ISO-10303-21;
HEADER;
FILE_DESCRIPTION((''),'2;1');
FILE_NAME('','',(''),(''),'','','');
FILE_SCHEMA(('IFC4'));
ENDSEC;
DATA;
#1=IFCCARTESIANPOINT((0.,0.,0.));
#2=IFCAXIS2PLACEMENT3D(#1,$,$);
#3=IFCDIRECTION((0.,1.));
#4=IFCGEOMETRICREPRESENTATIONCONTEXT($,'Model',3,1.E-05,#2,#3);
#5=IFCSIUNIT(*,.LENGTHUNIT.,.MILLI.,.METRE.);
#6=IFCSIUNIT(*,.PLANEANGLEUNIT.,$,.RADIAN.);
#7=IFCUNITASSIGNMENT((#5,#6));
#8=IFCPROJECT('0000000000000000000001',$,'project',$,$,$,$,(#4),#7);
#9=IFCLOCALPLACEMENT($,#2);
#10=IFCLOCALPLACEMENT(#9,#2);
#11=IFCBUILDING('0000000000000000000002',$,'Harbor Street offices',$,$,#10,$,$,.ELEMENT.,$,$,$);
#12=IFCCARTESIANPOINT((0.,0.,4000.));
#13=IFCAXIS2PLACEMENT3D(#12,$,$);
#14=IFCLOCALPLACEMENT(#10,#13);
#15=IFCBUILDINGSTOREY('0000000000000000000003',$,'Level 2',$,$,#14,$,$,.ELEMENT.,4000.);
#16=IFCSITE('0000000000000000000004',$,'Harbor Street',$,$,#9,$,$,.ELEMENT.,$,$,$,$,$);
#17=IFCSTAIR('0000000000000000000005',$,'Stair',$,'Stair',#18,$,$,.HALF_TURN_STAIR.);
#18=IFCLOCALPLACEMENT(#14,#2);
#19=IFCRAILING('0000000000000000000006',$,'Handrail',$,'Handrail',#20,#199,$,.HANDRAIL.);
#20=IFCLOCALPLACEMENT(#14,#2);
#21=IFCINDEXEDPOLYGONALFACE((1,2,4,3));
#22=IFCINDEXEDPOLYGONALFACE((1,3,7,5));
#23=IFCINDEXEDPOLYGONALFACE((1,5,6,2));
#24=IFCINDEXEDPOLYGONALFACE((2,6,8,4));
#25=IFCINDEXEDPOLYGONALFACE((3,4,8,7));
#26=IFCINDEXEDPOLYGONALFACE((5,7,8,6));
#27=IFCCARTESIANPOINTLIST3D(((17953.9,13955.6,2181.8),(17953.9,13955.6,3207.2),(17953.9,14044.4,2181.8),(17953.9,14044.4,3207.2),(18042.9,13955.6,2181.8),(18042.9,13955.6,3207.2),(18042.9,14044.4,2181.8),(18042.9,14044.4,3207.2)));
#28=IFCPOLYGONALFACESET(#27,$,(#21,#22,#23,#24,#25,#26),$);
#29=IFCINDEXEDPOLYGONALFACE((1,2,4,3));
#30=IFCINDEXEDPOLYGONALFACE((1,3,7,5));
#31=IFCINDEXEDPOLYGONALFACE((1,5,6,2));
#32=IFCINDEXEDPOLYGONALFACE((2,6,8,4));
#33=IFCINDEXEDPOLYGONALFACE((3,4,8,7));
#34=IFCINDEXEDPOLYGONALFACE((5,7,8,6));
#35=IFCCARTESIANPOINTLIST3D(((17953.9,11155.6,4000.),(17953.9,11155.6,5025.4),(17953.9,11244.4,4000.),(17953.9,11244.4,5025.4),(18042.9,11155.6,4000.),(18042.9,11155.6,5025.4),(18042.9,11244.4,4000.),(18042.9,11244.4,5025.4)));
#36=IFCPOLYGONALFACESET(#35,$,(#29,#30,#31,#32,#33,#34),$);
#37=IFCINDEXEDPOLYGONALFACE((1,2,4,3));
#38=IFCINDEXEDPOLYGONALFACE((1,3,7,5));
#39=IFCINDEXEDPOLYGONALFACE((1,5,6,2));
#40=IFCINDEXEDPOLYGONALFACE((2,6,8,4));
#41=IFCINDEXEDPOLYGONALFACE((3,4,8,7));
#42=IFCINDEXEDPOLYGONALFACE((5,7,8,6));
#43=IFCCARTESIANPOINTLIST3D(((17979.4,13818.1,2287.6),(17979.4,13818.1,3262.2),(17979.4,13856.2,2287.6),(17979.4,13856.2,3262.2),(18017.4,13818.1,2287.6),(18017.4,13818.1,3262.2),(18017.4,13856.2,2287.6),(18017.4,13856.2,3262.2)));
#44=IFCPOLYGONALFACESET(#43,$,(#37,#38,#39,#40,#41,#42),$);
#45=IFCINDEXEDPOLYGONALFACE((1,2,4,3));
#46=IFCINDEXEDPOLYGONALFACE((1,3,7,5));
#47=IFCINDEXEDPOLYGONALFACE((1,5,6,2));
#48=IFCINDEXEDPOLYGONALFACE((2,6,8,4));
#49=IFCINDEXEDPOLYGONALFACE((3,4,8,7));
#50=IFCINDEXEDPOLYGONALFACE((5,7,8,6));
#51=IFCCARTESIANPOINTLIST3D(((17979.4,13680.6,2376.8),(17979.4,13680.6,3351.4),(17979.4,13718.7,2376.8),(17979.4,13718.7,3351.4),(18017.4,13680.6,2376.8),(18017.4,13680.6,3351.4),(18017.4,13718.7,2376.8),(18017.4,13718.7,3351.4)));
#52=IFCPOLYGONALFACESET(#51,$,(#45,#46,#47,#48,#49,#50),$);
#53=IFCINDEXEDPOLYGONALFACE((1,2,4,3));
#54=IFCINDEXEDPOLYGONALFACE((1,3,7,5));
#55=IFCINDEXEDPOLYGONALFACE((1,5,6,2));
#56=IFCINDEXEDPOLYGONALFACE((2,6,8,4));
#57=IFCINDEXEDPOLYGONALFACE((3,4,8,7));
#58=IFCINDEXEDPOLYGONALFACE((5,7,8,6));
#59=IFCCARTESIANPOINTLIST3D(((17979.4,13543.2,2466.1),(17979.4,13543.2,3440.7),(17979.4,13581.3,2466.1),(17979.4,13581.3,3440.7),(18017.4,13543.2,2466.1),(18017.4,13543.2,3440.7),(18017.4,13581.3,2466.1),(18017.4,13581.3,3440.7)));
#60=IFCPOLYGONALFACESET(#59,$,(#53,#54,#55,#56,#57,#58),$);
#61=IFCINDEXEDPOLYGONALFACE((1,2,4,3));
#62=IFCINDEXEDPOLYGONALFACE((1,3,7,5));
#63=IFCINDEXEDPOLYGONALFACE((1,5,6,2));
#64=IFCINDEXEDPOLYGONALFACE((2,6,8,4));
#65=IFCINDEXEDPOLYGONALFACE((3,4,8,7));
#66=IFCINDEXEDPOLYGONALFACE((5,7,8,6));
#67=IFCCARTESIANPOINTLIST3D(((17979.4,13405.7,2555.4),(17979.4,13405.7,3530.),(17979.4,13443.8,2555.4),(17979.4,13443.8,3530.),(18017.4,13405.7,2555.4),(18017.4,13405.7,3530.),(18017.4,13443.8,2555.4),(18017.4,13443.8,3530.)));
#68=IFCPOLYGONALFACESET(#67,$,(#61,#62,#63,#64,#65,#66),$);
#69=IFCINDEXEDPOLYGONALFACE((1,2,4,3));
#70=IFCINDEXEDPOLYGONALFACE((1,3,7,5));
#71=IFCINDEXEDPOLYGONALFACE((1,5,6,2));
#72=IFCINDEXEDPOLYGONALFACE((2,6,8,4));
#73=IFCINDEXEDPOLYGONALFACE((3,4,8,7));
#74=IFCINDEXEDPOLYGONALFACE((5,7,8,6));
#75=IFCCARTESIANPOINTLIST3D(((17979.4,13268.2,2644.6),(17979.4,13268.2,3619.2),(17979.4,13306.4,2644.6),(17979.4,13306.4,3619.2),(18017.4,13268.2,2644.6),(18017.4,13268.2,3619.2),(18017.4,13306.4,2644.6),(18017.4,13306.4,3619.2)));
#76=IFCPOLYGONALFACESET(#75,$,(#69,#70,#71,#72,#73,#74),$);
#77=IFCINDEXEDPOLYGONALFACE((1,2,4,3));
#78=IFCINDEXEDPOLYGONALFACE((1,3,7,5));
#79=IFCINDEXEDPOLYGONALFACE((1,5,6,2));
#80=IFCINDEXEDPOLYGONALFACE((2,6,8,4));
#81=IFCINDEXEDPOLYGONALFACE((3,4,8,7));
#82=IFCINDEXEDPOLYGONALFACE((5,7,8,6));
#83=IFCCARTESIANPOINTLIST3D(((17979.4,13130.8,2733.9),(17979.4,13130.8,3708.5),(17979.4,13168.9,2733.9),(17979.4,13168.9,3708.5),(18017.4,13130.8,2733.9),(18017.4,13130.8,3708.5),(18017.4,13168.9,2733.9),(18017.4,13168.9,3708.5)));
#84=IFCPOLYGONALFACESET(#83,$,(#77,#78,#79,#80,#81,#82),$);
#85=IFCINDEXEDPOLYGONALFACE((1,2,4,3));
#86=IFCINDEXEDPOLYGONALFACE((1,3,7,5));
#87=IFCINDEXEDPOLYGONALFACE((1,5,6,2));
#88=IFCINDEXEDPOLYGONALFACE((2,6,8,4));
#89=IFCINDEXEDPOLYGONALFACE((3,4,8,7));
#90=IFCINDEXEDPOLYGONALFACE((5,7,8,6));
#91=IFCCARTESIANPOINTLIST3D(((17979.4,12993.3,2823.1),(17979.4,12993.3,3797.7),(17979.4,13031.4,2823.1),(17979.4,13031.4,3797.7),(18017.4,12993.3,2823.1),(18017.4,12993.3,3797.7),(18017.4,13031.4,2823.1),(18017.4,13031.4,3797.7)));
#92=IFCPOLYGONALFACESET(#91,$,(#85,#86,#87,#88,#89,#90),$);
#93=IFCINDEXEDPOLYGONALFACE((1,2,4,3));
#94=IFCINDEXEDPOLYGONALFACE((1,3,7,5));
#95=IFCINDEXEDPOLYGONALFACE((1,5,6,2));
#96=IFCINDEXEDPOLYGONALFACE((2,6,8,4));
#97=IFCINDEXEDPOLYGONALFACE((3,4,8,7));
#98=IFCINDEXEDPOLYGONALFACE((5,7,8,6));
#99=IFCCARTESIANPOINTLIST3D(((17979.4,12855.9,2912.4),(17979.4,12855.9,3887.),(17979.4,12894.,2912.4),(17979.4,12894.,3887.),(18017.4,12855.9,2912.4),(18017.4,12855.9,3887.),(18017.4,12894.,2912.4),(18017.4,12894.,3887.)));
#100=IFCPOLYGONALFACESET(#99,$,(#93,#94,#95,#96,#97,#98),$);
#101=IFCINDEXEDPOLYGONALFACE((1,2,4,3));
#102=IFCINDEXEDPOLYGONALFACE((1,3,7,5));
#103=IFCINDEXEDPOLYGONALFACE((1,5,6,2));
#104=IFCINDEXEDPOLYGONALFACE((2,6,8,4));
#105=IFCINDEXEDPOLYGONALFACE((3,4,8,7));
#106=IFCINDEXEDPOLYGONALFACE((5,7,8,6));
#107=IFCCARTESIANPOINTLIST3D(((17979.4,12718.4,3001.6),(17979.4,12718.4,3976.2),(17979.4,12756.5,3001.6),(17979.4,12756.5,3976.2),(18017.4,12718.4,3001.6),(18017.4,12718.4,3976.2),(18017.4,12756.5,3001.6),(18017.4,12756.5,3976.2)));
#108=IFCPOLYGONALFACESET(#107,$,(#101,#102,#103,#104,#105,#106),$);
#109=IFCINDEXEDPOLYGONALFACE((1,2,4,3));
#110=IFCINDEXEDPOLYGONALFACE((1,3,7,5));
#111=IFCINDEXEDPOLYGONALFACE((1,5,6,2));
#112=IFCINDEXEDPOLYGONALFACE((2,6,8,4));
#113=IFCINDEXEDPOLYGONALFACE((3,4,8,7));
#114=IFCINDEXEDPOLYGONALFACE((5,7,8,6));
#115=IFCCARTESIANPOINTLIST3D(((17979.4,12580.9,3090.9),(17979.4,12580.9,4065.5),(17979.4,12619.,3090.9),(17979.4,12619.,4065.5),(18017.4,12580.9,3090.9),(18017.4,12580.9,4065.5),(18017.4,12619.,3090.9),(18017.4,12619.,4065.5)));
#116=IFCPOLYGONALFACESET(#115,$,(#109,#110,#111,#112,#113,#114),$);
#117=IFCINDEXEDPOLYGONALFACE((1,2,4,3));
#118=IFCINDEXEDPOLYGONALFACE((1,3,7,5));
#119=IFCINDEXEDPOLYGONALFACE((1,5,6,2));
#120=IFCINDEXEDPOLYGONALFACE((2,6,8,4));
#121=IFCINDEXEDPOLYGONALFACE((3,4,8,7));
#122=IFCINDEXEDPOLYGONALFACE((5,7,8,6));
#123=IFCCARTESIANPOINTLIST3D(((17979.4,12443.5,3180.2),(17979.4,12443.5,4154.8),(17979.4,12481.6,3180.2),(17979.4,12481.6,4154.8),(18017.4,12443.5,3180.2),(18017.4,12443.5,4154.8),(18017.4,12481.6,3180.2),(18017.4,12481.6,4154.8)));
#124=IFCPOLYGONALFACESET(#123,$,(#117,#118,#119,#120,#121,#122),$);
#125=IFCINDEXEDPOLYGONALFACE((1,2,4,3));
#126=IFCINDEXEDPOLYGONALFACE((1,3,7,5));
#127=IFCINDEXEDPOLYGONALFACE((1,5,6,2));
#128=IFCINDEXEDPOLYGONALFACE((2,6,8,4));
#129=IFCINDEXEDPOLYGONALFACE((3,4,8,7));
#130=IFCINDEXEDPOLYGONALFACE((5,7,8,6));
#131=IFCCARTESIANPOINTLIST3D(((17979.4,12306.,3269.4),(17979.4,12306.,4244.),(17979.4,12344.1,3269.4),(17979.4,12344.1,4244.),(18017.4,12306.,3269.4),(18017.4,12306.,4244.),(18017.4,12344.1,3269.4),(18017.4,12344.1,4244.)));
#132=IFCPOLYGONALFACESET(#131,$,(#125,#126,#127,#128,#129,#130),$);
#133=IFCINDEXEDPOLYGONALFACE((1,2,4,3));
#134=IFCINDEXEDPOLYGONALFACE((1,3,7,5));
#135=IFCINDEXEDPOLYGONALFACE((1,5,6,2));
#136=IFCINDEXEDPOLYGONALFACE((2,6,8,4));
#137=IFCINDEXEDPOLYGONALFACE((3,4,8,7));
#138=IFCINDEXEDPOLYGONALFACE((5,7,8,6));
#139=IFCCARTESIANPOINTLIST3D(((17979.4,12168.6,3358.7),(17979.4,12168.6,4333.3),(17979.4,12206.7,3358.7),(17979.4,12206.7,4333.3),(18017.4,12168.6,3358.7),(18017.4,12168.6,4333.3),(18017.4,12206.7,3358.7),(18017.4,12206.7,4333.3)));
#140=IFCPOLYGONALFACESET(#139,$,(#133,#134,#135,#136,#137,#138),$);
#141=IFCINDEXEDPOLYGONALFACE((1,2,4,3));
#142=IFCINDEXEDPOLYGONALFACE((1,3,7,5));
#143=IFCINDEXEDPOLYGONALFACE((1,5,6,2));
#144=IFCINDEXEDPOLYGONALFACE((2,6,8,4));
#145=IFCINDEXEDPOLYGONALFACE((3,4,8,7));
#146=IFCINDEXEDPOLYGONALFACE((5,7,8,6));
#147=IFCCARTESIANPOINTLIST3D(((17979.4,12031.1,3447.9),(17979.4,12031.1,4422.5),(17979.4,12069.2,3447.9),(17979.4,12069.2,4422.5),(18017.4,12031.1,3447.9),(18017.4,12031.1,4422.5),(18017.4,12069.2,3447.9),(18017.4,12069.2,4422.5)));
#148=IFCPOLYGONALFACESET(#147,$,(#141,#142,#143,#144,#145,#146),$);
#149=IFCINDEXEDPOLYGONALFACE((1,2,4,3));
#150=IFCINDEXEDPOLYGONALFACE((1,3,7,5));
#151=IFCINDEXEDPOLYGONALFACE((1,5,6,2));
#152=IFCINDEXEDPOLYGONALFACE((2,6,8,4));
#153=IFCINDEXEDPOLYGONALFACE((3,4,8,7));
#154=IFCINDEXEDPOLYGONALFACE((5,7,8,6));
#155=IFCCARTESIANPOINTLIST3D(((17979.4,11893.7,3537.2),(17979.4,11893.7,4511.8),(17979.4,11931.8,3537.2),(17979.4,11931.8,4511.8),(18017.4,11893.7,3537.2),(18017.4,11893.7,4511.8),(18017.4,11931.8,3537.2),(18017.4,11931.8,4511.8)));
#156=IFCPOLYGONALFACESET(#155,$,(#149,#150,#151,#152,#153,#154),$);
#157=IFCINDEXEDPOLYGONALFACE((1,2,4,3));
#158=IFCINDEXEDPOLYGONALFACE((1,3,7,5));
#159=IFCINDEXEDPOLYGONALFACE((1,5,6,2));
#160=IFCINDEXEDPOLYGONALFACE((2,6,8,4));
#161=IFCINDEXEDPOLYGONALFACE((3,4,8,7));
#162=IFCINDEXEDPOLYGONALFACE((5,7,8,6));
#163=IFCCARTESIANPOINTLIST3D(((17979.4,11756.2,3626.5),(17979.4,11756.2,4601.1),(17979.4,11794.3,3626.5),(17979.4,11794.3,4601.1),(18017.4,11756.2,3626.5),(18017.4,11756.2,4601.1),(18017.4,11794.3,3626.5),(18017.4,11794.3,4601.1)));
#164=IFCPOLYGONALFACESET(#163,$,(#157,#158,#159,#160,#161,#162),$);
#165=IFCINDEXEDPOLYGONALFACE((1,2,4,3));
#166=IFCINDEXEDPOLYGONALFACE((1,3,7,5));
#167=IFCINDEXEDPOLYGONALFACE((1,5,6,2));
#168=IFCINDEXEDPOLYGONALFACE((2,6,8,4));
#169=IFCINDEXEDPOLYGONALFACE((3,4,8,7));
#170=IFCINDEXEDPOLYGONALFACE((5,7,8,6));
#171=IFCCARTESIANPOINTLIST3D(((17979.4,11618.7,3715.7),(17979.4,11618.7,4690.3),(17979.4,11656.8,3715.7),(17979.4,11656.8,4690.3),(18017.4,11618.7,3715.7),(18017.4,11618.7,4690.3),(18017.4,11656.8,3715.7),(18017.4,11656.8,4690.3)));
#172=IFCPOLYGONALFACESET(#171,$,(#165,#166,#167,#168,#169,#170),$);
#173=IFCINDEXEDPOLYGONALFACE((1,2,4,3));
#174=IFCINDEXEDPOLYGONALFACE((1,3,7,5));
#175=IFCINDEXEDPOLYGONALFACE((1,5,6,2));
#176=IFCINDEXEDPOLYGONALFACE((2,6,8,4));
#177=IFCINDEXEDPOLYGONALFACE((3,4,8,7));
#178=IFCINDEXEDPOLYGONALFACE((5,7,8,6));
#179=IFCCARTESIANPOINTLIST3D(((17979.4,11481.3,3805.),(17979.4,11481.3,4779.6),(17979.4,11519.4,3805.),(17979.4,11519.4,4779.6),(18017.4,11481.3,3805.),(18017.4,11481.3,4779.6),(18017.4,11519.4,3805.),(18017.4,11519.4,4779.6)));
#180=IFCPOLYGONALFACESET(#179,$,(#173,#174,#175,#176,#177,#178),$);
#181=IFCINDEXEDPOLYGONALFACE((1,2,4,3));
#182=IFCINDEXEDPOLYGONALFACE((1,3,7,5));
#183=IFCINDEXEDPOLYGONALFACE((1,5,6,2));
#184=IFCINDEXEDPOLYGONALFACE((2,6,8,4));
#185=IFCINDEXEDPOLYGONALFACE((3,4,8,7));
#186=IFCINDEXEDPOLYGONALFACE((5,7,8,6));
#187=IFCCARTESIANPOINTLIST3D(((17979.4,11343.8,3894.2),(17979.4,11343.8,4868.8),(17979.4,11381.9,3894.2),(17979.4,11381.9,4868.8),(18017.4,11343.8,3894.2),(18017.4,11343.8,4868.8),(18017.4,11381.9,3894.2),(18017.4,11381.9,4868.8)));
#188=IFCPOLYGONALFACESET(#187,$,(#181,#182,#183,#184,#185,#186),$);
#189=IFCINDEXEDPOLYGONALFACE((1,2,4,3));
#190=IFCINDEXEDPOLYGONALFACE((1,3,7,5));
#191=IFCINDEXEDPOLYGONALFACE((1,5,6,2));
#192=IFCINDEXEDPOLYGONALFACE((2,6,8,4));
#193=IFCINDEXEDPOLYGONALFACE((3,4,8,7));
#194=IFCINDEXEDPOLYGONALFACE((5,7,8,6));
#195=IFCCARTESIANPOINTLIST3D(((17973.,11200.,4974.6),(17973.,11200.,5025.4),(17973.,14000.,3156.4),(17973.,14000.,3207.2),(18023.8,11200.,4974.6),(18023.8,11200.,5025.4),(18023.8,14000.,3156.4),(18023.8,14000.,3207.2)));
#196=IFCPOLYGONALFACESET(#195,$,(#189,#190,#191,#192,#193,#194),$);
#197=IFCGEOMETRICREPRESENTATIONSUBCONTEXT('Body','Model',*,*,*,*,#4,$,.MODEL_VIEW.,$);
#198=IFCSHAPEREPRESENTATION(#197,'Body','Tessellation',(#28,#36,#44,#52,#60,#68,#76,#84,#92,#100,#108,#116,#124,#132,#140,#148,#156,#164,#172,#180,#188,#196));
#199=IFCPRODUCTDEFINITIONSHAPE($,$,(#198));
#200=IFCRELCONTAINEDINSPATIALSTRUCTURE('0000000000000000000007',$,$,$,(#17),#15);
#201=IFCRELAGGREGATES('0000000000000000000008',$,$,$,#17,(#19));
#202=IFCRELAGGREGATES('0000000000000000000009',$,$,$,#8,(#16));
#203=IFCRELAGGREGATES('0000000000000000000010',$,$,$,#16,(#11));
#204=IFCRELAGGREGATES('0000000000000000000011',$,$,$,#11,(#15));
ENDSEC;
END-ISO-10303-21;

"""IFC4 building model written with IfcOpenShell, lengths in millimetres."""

from ifc_helpers import new_model, si_unit, direction, frame, origin, origin_with_axes, place, context, subcontext, project, spatial, polyline, outline, extrude, element, aggregate, save


model = new_model("IFC4")

# Units and contexts
model_context = context("Model", 3, precision=1e-05, world=origin(), true_north=direction((0.0, 1.0)))
body_context = subcontext(model_context, "Body", "Model", "MODEL_VIEW")
ifc_project = project(units=[si_unit("LENGTHUNIT", "METRE", prefix="MILLI"), si_unit("PLANEANGLEUNIT", "RADIAN")], contexts=[model_context])

# Site, building, storey
site_placement = place(None, origin())
site = spatial("IfcSite", under=ifc_project, at=site_placement, Name="Harbor Street", CompositionType="ELEMENT")
building_placement = place(site_placement, origin())
building = spatial("IfcBuilding", under=site, at=building_placement, Name="Harbor Street offices", CompositionType="ELEMENT")
storey_placement = place(building_placement, frame((0.0, 0.0, 4000.0)))
storey = spatial("IfcBuildingStorey", under=building, at=storey_placement, Name="Level 2", CompositionType="ELEMENT", Elevation=4000.0)

# Stair
stair_placement = place(storey_placement, origin_with_axes())
stair = element("IfcStair", 1, at=stair_placement, inside=storey, Name="Stair", ObjectType="Stair", PredefinedType="HALF_TURN_STAIR")

# Railing
railing_1_placement = place(storey_placement, origin_with_axes())
railing_1 = element("IfcRailing", 2, at=railing_1_placement, Name="Handrail", ObjectType="Handrail", PredefinedType="HANDRAIL", context=body_context, shape_type="SweptSolid", body=[
    extrude(outline(polyline([(-44.5, -44.5), (44.5, -44.5), (44.5, 44.5), (-44.5, 44.5), (-44.5, -44.5)])), frame((17998.4, 14000.0, 2181.8), z_axis=(0.0, 0.0, 1.0), x_axis=(1.0, 0.0, 0.0)), (0.0, 0.0, 1.0), 1025.4),
    extrude(outline(polyline([(-44.5, -44.5), (44.5, -44.5), (44.5, 44.5), (-44.5, 44.5), (-44.5, -44.5)])), frame((17998.4, 11200.0, 4000.0), z_axis=(0.0, 0.0, 1.0), x_axis=(1.0, 0.0, 0.0)), (0.0, 0.0, 1.0), 1025.4),
    extrude(outline(polyline([(-19.1, -19.1), (19.1, -19.1), (19.1, 19.1), (-19.1, 19.1), (-19.1, -19.1)])), frame((17998.4, 13837.1, 2287.6), z_axis=(0.0, 0.0, 1.0), x_axis=(1.0, 0.0, 0.0)), (0.0, 0.0, 1.0), 974.6),
    extrude(outline(polyline([(-19.1, -19.1), (19.1, -19.1), (19.1, 19.1), (-19.1, 19.1), (-19.1, -19.1)])), frame((17998.4, 13699.7, 2376.8), z_axis=(0.0, 0.0, 1.0), x_axis=(1.0, 0.0, 0.0)), (0.0, 0.0, 1.0), 974.6),
    extrude(outline(polyline([(-19.1, -19.1), (19.1, -19.1), (19.1, 19.1), (-19.1, 19.1), (-19.1, -19.1)])), frame((17998.4, 13562.2, 2466.1), z_axis=(0.0, 0.0, 1.0), x_axis=(1.0, 0.0, 0.0)), (0.0, 0.0, 1.0), 974.6),
    extrude(outline(polyline([(-19.1, -19.1), (19.1, -19.1), (19.1, 19.1), (-19.1, 19.1), (-19.1, -19.1)])), frame((17998.4, 13424.8, 2555.4), z_axis=(0.0, 0.0, 1.0), x_axis=(1.0, 0.0, 0.0)), (0.0, 0.0, 1.0), 974.6),
    extrude(outline(polyline([(-19.1, -19.1), (19.1, -19.1), (19.1, 19.1), (-19.1, 19.1), (-19.1, -19.1)])), frame((17998.4, 13287.3, 2644.6), z_axis=(0.0, 0.0, 1.0), x_axis=(1.0, 0.0, 0.0)), (0.0, 0.0, 1.0), 974.6),
    extrude(outline(polyline([(-19.1, -19.1), (19.1, -19.1), (19.1, 19.1), (-19.1, 19.1), (-19.1, -19.1)])), frame((17998.4, 13149.8, 2733.9), z_axis=(0.0, 0.0, 1.0), x_axis=(1.0, 0.0, 0.0)), (0.0, 0.0, 1.0), 974.6),
    extrude(outline(polyline([(-19.1, -19.1), (19.1, -19.1), (19.1, 19.1), (-19.1, 19.1), (-19.1, -19.1)])), frame((17998.4, 13012.4, 2823.1), z_axis=(0.0, 0.0, 1.0), x_axis=(1.0, 0.0, 0.0)), (0.0, 0.0, 1.0), 974.6),
    extrude(outline(polyline([(-19.1, -19.1), (19.1, -19.1), (19.1, 19.1), (-19.1, 19.1), (-19.1, -19.1)])), frame((17998.4, 12874.9, 2912.4), z_axis=(0.0, 0.0, 1.0), x_axis=(1.0, 0.0, 0.0)), (0.0, 0.0, 1.0), 974.6),
    extrude(outline(polyline([(-19.1, -19.1), (19.1, -19.1), (19.1, 19.1), (-19.1, 19.1), (-19.1, -19.1)])), frame((17998.4, 12737.5, 3001.6), z_axis=(0.0, 0.0, 1.0), x_axis=(1.0, 0.0, 0.0)), (0.0, 0.0, 1.0), 974.6),
    extrude(outline(polyline([(-19.1, -19.1), (19.1, -19.1), (19.1, 19.1), (-19.1, 19.1), (-19.1, -19.1)])), frame((17998.4, 12600.0, 3090.9), z_axis=(0.0, 0.0, 1.0), x_axis=(1.0, 0.0, 0.0)), (0.0, 0.0, 1.0), 974.6),
    extrude(outline(polyline([(-19.1, -19.1), (19.1, -19.1), (19.1, 19.1), (-19.1, 19.1), (-19.1, -19.1)])), frame((17998.4, 12462.5, 3180.2), z_axis=(0.0, 0.0, 1.0), x_axis=(1.0, 0.0, 0.0)), (0.0, 0.0, 1.0), 974.6),
    extrude(outline(polyline([(-19.1, -19.1), (19.1, -19.1), (19.1, 19.1), (-19.1, 19.1), (-19.1, -19.1)])), frame((17998.4, 12325.1, 3269.4), z_axis=(0.0, 0.0, 1.0), x_axis=(1.0, 0.0, 0.0)), (0.0, 0.0, 1.0), 974.6),
    extrude(outline(polyline([(-19.1, -19.1), (19.1, -19.1), (19.1, 19.1), (-19.1, 19.1), (-19.1, -19.1)])), frame((17998.4, 12187.6, 3358.7), z_axis=(0.0, 0.0, 1.0), x_axis=(1.0, 0.0, 0.0)), (0.0, 0.0, 1.0), 974.6),
    extrude(outline(polyline([(-19.1, -19.1), (19.1, -19.1), (19.1, 19.1), (-19.1, 19.1), (-19.1, -19.1)])), frame((17998.4, 12050.2, 3447.9), z_axis=(0.0, 0.0, 1.0), x_axis=(1.0, 0.0, 0.0)), (0.0, 0.0, 1.0), 974.6),
    extrude(outline(polyline([(-19.1, -19.1), (19.1, -19.1), (19.1, 19.1), (-19.1, 19.1), (-19.1, -19.1)])), frame((17998.4, 11912.7, 3537.2), z_axis=(0.0, 0.0, 1.0), x_axis=(1.0, 0.0, 0.0)), (0.0, 0.0, 1.0), 974.6),
    extrude(outline(polyline([(-19.1, -19.1), (19.1, -19.1), (19.1, 19.1), (-19.1, 19.1), (-19.1, -19.1)])), frame((17998.4, 11775.2, 3626.5), z_axis=(0.0, 0.0, 1.0), x_axis=(1.0, 0.0, 0.0)), (0.0, 0.0, 1.0), 974.6),
    extrude(outline(polyline([(-19.1, -19.1), (19.1, -19.1), (19.1, 19.1), (-19.1, 19.1), (-19.1, -19.1)])), frame((17998.4, 11637.8, 3715.7), z_axis=(0.0, 0.0, 1.0), x_axis=(1.0, 0.0, 0.0)), (0.0, 0.0, 1.0), 974.6),
    extrude(outline(polyline([(-19.1, -19.1), (19.1, -19.1), (19.1, 19.1), (-19.1, 19.1), (-19.1, -19.1)])), frame((17998.4, 11500.3, 3805.0), z_axis=(0.0, 0.0, 1.0), x_axis=(1.0, 0.0, 0.0)), (0.0, 0.0, 1.0), 974.6),
    extrude(outline(polyline([(-19.1, -19.1), (19.1, -19.1), (19.1, 19.1), (-19.1, 19.1), (-19.1, -19.1)])), frame((17998.4, 11362.9, 3894.2), z_axis=(0.0, 0.0, 1.0), x_axis=(1.0, 0.0, 0.0)), (0.0, 0.0, 1.0), 974.6),
    extrude(outline(polyline([(0.0, 0.0), (50.8, 0.0), (50.8, 50.8), (0.0, 50.8), (0.0, 0.0)])), frame((17973.0, 14000.0, 3156.4), z_axis=(0.0, -1.0, 0.0), x_axis=(1.0, 0.0, 0.0)), (0.0, 0.544605, 0.838692), 3338.5),
])
aggregate(stair, [railing_1])

save(model, "model.ifc")
